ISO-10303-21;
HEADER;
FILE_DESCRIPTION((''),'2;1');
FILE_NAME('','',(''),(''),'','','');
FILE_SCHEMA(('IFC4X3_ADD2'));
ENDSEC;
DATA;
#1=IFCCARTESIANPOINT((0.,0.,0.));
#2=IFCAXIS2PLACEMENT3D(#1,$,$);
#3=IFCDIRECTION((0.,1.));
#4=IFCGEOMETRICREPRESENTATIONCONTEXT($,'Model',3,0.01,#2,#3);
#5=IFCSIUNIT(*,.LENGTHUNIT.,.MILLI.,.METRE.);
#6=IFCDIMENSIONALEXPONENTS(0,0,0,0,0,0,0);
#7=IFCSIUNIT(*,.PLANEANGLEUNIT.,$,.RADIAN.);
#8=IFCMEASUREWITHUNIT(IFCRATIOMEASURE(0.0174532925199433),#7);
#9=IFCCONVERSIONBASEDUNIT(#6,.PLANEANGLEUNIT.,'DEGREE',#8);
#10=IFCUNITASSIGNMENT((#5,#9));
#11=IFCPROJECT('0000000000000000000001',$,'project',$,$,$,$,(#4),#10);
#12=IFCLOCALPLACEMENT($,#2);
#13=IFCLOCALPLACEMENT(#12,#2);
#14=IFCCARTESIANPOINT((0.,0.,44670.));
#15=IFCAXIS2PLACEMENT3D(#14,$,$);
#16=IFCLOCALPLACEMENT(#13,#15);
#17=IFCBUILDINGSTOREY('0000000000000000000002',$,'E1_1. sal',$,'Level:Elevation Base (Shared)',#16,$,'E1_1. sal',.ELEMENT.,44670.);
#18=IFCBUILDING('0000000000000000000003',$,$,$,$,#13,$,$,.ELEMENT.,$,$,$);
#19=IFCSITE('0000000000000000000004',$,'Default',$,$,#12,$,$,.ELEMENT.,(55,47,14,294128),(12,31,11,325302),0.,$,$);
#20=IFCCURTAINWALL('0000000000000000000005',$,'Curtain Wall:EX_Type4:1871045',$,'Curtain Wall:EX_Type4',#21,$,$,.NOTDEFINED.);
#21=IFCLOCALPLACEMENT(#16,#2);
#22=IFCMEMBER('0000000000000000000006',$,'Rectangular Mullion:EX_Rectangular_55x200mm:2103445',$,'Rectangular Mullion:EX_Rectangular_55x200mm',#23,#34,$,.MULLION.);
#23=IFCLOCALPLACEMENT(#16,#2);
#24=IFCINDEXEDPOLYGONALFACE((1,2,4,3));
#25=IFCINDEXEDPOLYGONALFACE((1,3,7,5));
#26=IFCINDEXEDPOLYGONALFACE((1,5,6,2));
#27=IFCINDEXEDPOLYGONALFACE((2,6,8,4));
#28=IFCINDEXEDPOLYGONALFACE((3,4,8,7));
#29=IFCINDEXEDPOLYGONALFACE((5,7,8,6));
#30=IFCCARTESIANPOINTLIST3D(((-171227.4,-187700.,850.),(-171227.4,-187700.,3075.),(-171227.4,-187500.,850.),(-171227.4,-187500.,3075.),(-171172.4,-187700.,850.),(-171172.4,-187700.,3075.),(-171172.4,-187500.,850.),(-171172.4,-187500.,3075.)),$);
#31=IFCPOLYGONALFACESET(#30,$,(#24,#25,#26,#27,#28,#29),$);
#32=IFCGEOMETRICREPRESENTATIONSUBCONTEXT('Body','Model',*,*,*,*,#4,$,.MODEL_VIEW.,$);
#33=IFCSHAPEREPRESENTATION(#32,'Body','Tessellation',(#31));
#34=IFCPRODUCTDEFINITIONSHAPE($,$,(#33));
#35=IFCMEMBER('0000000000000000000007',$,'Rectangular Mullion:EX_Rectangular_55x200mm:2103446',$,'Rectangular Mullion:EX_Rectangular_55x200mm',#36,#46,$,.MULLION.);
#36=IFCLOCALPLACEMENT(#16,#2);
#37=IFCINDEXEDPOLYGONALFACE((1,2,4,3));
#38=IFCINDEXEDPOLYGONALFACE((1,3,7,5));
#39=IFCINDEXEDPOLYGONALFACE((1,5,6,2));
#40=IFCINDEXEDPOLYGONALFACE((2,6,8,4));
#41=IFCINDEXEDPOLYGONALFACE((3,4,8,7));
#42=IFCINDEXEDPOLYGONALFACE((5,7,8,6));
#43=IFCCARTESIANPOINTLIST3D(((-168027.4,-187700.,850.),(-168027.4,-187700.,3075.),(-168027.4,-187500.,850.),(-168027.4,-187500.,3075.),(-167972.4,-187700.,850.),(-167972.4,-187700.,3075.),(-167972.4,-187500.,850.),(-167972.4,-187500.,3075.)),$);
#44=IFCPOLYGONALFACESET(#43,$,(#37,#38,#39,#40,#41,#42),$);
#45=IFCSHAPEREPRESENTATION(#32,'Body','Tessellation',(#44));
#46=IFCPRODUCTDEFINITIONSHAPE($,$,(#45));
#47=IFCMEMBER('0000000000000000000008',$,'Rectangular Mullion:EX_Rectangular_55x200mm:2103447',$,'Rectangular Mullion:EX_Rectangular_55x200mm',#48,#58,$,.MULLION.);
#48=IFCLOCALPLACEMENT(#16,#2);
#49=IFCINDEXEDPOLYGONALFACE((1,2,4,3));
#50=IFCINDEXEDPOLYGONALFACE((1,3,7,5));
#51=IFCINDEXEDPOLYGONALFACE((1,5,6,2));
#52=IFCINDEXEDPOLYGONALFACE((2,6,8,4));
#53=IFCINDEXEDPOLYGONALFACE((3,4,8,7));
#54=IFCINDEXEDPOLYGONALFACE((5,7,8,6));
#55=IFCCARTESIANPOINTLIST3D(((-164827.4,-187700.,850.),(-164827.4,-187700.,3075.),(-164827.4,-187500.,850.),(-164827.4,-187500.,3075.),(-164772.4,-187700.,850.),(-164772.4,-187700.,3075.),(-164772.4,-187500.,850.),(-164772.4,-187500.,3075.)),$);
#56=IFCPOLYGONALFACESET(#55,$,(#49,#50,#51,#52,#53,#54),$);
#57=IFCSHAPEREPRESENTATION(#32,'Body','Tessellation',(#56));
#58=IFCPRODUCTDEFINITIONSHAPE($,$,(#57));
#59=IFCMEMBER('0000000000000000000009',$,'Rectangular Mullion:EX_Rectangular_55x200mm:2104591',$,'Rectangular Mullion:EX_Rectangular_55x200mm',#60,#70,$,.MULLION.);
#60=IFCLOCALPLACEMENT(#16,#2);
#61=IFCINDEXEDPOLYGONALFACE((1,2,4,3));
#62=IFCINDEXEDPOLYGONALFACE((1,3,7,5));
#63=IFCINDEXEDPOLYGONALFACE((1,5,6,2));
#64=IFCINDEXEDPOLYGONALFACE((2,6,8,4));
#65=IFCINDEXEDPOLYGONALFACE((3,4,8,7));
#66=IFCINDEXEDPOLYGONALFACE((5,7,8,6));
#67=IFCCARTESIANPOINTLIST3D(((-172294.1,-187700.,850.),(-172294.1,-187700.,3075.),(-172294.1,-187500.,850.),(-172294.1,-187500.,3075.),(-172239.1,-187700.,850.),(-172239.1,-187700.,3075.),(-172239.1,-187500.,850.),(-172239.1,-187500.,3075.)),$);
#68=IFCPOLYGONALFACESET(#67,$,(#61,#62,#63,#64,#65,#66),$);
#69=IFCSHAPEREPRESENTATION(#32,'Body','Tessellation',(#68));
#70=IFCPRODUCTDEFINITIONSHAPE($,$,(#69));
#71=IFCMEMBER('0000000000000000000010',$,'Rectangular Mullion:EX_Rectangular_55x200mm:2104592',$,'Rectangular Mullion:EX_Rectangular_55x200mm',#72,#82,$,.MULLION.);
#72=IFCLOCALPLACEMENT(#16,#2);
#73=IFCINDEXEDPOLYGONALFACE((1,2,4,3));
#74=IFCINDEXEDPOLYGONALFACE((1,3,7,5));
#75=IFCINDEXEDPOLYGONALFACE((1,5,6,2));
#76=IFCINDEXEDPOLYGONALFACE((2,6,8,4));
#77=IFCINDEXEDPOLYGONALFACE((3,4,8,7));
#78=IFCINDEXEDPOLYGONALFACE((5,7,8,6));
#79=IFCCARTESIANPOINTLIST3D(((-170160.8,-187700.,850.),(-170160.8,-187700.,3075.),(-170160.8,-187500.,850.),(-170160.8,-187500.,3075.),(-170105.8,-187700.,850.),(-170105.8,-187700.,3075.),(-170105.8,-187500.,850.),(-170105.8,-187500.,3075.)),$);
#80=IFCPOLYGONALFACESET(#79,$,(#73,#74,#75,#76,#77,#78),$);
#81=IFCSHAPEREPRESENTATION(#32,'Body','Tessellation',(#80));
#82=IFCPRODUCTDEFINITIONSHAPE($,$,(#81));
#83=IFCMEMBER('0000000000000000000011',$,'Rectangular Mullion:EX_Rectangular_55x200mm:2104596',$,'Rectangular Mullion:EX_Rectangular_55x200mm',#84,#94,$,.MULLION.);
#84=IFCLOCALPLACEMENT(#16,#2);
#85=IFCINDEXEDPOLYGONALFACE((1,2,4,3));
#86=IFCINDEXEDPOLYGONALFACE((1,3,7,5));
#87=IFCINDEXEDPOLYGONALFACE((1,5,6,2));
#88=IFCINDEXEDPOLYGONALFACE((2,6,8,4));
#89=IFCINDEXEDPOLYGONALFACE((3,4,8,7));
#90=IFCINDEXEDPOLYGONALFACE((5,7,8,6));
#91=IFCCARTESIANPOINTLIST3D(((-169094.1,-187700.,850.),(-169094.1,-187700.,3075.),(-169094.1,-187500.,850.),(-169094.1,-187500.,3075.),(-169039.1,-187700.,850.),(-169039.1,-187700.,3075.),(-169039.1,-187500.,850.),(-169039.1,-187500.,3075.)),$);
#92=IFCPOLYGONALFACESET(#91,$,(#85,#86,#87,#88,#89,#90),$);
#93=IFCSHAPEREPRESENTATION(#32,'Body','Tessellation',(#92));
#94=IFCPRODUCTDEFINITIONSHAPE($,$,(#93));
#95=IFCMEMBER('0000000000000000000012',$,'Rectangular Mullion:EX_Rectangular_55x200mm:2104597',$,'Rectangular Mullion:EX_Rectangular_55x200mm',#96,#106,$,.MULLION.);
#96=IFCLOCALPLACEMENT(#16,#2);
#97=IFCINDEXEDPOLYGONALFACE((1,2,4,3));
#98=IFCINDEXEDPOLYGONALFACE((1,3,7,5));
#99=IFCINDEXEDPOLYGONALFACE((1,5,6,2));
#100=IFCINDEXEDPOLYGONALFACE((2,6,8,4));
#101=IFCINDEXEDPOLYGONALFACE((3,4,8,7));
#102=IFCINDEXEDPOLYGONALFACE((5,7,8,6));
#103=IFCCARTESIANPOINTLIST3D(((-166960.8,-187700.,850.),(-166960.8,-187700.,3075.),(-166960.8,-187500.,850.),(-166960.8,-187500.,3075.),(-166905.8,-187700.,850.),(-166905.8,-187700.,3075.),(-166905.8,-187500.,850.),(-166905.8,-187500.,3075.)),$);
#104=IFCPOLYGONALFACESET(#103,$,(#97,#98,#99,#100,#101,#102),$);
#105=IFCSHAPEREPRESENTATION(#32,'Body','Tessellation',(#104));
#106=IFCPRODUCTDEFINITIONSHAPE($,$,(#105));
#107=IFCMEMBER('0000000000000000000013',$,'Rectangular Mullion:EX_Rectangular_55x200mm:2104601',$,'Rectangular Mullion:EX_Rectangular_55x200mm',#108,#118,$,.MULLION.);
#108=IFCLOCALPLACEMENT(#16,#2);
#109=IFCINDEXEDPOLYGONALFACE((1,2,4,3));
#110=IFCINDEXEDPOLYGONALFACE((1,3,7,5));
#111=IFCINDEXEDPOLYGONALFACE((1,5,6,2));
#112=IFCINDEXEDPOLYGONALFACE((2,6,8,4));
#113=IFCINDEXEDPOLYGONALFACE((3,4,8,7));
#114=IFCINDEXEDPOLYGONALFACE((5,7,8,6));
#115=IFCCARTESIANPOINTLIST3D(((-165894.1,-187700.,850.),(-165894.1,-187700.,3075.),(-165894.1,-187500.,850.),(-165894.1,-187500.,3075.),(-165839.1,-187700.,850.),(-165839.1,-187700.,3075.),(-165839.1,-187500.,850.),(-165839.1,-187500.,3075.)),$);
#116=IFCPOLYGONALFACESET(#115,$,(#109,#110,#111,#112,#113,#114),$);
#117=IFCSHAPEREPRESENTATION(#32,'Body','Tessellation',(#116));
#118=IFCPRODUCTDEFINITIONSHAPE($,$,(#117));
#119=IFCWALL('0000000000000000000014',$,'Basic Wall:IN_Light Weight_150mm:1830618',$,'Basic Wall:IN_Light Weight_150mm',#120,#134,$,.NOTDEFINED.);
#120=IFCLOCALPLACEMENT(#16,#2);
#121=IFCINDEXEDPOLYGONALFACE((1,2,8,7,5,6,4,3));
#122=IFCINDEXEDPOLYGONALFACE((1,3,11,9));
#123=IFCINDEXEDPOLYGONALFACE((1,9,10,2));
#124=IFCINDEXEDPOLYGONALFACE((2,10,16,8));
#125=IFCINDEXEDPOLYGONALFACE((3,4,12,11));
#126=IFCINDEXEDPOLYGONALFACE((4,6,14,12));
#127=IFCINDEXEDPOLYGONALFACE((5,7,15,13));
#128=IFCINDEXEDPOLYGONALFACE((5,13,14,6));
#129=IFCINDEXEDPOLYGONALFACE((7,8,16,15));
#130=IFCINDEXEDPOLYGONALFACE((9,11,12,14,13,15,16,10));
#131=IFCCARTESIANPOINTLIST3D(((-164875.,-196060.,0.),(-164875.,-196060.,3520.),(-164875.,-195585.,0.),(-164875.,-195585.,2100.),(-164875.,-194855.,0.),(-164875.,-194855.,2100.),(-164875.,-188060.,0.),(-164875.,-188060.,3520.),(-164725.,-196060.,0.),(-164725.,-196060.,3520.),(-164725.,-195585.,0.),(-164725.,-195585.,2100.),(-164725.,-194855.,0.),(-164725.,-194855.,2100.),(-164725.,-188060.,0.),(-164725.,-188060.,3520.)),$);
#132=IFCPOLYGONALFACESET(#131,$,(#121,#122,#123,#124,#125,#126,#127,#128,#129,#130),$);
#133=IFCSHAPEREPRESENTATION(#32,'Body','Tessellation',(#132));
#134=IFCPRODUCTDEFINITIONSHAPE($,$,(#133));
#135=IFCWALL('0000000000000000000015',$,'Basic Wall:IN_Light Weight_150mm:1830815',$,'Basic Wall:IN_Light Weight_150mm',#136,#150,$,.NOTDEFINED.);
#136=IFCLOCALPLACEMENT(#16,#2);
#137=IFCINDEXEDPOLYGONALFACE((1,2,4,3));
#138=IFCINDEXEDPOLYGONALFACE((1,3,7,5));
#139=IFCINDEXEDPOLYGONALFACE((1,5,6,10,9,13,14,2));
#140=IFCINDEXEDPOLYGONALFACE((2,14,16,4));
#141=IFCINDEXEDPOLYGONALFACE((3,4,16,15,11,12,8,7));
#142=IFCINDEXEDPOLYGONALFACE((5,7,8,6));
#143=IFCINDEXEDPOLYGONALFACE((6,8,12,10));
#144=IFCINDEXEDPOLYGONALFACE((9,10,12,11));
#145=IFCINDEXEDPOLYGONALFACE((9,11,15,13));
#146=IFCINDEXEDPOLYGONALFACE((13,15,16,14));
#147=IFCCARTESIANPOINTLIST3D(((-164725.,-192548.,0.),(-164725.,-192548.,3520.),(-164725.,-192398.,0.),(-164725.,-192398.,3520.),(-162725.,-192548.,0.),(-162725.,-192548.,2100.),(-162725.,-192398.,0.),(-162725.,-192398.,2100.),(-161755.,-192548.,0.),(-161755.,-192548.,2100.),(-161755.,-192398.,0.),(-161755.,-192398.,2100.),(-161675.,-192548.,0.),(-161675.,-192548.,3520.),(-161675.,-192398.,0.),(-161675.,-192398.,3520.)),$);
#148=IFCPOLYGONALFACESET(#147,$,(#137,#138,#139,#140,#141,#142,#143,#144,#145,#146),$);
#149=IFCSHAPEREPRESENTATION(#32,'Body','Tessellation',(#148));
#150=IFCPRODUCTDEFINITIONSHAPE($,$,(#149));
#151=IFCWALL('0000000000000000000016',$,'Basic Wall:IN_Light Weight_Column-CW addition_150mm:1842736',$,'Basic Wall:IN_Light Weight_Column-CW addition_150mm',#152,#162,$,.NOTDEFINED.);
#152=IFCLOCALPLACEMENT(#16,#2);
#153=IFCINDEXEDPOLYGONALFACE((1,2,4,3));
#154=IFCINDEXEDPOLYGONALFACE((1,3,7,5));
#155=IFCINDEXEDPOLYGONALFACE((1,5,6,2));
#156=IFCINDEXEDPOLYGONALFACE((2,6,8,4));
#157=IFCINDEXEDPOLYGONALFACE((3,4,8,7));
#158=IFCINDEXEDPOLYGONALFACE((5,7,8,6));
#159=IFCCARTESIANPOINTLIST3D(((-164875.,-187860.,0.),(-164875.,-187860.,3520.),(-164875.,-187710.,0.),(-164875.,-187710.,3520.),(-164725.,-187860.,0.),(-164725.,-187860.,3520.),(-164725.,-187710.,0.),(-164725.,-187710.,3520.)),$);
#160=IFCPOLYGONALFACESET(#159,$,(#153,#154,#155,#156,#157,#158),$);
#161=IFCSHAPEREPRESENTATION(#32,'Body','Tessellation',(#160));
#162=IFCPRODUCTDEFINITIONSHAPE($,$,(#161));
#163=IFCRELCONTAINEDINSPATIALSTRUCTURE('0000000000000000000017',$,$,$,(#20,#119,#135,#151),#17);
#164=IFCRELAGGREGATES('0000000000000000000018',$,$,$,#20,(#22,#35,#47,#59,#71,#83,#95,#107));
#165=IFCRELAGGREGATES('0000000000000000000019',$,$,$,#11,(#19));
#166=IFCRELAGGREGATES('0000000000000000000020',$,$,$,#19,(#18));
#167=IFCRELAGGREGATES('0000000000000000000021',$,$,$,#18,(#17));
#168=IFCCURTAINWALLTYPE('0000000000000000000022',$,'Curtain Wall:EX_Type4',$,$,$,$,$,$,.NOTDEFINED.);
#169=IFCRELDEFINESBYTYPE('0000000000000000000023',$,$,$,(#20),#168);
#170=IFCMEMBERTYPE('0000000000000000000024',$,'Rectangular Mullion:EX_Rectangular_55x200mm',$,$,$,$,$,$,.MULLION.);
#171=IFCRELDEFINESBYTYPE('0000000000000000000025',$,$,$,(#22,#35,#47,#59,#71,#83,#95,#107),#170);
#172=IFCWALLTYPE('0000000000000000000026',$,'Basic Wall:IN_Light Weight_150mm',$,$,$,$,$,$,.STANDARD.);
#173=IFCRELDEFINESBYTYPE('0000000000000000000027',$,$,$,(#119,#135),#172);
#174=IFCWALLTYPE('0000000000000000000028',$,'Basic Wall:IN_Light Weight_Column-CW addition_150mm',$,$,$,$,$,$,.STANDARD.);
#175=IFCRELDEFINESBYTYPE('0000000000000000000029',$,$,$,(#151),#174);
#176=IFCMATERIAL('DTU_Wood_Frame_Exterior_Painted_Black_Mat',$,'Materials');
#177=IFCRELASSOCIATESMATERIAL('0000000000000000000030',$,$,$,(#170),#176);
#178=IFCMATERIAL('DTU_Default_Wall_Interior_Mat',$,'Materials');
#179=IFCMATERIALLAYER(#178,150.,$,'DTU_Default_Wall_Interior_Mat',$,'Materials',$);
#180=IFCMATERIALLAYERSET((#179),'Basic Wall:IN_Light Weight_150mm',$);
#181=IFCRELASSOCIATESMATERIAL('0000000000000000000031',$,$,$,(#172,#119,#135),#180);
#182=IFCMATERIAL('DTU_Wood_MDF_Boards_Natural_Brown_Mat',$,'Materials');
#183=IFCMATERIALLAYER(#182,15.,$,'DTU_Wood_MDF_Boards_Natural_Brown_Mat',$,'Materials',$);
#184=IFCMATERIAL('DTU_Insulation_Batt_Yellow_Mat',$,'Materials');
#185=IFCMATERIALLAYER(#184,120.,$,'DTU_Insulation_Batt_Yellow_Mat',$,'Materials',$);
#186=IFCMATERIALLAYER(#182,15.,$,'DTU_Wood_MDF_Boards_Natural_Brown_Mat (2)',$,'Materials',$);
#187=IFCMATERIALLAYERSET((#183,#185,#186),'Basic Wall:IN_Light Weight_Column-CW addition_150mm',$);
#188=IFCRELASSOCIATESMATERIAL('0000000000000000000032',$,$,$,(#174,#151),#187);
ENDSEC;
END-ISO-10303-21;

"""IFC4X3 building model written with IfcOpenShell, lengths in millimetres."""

from ifc_helpers import new_model, entity, si_unit, converted_unit, direction, frame, frame_2d, origin, origin_2d_with_axis, place, context, subcontext, project, spatial, rectangle, extrude, source, transform, mapped, material, layer, layer_set, material_profile, profile_set, type_object, type_shapes, element, aggregate, save


model = new_model("IFC4X3")

# Units and contexts
model_context = context("Model", 3, precision=0.01, world=origin(), true_north=direction((0.0, 1.0)))
body_context = subcontext(model_context, "Body", "Model", "MODEL_VIEW")
ifc_project = project(units=[si_unit("LENGTHUNIT", "METRE", prefix="MILLI"), converted_unit("PLANEANGLEUNIT", "DEGREE", entity("IfcRatioMeasure", 0.0174532925199433), si_unit("PLANEANGLEUNIT", "RADIAN"), dimensions=[0, 0, 0, 0, 0, 0, 0])], contexts=[model_context])

# Site, building, storey
site_placement = place(None, origin())
site = spatial("IfcSite", under=ifc_project, at=site_placement, Name="Default", CompositionType="ELEMENT", RefLatitude=(55, 47, 14, 294128), RefLongitude=(12, 31, 11, 325302), RefElevation=0.0)
building_placement = place(site_placement, origin())
building = spatial("IfcBuilding", under=site, at=building_placement, CompositionType="ELEMENT")
storey_placement = place(building_placement, frame((0.0, 0.0, 44670.0)))
storey = spatial("IfcBuildingStorey", under=building, at=storey_placement, Name="E1_1. sal", ObjectType="Level:Elevation Base (Shared)", LongName="E1_1. sal", CompositionType="ELEMENT", Elevation=44670.0)

# Curtain wall, members
curtain_wall_type = type_object("IfcCurtainWallType", Name="Curtain Wall:EX_Type4", PredefinedType="NOTDEFINED")
curtain_wall_placement = place(storey_placement, frame((0.0, 0.0, -44670.0)))
curtain_wall = element("IfcCurtainWall", 1, at=curtain_wall_placement, inside=storey, type_object=curtain_wall_type, Name="Curtain Wall:EX_Type4:1871045", ObjectType="Curtain Wall:EX_Type4", PredefinedType="NOTDEFINED")
ifc_material_1 = material(Name="DTU_Wood_Frame_Exterior_Painted_Black_Mat", Category="Materials")
ifc_material_profile = material_profile(ifc_material_1, rectangle(XDim=200.0, YDim=55.0, at=origin_2d_with_axis()), Name="EX_Rectangular_55x200mm")
ifc_profile_set = profile_set([ifc_material_profile], Name="EX_Rectangular_55x200mm")
member_type = type_object("IfcMemberType", Name="Rectangular Mullion:EX_Rectangular_55x200mm", PredefinedType="MULLION", material=ifc_profile_set)
shared_shape_1 = source(origin(), body_context, "Body", "SweptSolid", [
    extrude(rectangle(XDim=200.0, YDim=55.0, at=origin_2d_with_axis()), frame((0.0, -100.0, -2225.0), z_axis=(0.0, 0.0, 1.0), x_axis=(0.0, -1.0, 0.0)), (0.0, 0.0, 1.0), 2225.0),
])
type_shapes(member_type, [shared_shape_1])
member_1_placement = place(curtain_wall_placement, frame((-171199.9, -187500.0, 45520.0), z_axis=(0.0, 0.0, -1.0), x_axis=(-1.0, 0.0, 0.0)))
member_1 = element("IfcMember", 2, at=member_1_placement, type_object=member_type, Name="Rectangular Mullion:EX_Rectangular_55x200mm:2103445", ObjectType="Rectangular Mullion:EX_Rectangular_55x200mm", PredefinedType="MULLION", context=body_context, shape_type="MappedRepresentation", body=[
    mapped(shared_shape_1, transform((0.0, 0.0, 0.0), scale=1.0)),
])
member_2_placement = place(curtain_wall_placement, frame((-167999.9, -187500.0, 45520.0), z_axis=(0.0, 0.0, -1.0), x_axis=(-1.0, 0.0, 0.0)))
member_2 = element("IfcMember", 3, at=member_2_placement, type_object=member_type, Name="Rectangular Mullion:EX_Rectangular_55x200mm:2103446", ObjectType="Rectangular Mullion:EX_Rectangular_55x200mm", PredefinedType="MULLION", context=body_context, shape_type="MappedRepresentation", body=[
    mapped(shared_shape_1, transform((0.0, 0.0, 0.0), scale=1.0)),
])
member_3_placement = place(curtain_wall_placement, frame((-164799.9, -187500.0, 45520.0), z_axis=(0.0, 0.0, -1.0), x_axis=(-1.0, 0.0, 0.0)))
member_3 = element("IfcMember", 4, at=member_3_placement, type_object=member_type, Name="Rectangular Mullion:EX_Rectangular_55x200mm:2103447", ObjectType="Rectangular Mullion:EX_Rectangular_55x200mm", PredefinedType="MULLION", context=body_context, shape_type="MappedRepresentation", body=[
    mapped(shared_shape_1, transform((0.0, 0.0, 0.0), scale=1.0)),
])
member_4_placement = place(curtain_wall_placement, frame((-172266.6, -187500.0, 45520.0), z_axis=(0.0, 0.0, -1.0), x_axis=(-1.0, 0.0, 0.0)))
member_4 = element("IfcMember", 5, at=member_4_placement, type_object=member_type, Name="Rectangular Mullion:EX_Rectangular_55x200mm:2104591", ObjectType="Rectangular Mullion:EX_Rectangular_55x200mm", PredefinedType="MULLION", context=body_context, shape_type="MappedRepresentation", body=[
    mapped(shared_shape_1, transform((0.0, 0.0, 0.0), scale=1.0)),
])
member_5_placement = place(curtain_wall_placement, frame((-170133.3, -187500.0, 45520.0), z_axis=(0.0, 0.0, -1.0), x_axis=(-1.0, 0.0, 0.0)))
member_5 = element("IfcMember", 6, at=member_5_placement, type_object=member_type, Name="Rectangular Mullion:EX_Rectangular_55x200mm:2104592", ObjectType="Rectangular Mullion:EX_Rectangular_55x200mm", PredefinedType="MULLION", context=body_context, shape_type="MappedRepresentation", body=[
    mapped(shared_shape_1, transform((0.0, 0.0, 0.0), scale=1.0)),
])
member_6_placement = place(curtain_wall_placement, frame((-169066.6, -187500.0, 45520.0), z_axis=(0.0, 0.0, -1.0), x_axis=(-1.0, 0.0, 0.0)))
member_6 = element("IfcMember", 7, at=member_6_placement, type_object=member_type, Name="Rectangular Mullion:EX_Rectangular_55x200mm:2104596", ObjectType="Rectangular Mullion:EX_Rectangular_55x200mm", PredefinedType="MULLION", context=body_context, shape_type="MappedRepresentation", body=[
    mapped(shared_shape_1, transform((0.0, 0.0, 0.0), scale=1.0)),
])
member_7_placement = place(curtain_wall_placement, frame((-166933.3, -187500.0, 45520.0), z_axis=(0.0, 0.0, -1.0), x_axis=(-1.0, 0.0, 0.0)))
member_7 = element("IfcMember", 8, at=member_7_placement, type_object=member_type, Name="Rectangular Mullion:EX_Rectangular_55x200mm:2104597", ObjectType="Rectangular Mullion:EX_Rectangular_55x200mm", PredefinedType="MULLION", context=body_context, shape_type="MappedRepresentation", body=[
    mapped(shared_shape_1, transform((0.0, 0.0, 0.0), scale=1.0)),
])
member_8_placement = place(curtain_wall_placement, frame((-165866.6, -187500.0, 45520.0), z_axis=(0.0, 0.0, -1.0), x_axis=(-1.0, 0.0, 0.0)))
member_8 = element("IfcMember", 9, at=member_8_placement, type_object=member_type, Name="Rectangular Mullion:EX_Rectangular_55x200mm:2104601", ObjectType="Rectangular Mullion:EX_Rectangular_55x200mm", PredefinedType="MULLION", context=body_context, shape_type="MappedRepresentation", body=[
    mapped(shared_shape_1, transform((0.0, 0.0, 0.0), scale=1.0)),
])

# Walls, openings
ifc_material_2 = material(Name="DTU_Default_Wall_Interior_Mat", Category="Materials")
ifc_layer_1 = layer(ifc_material_2, 150.0, Name="DTU_Default_Wall_Interior_Mat", Category="Materials")
ifc_layer_set_1 = layer_set([ifc_layer_1], Name="Basic Wall:IN_Light Weight_150mm")
wall_type_1 = type_object("IfcWallType", Name="Basic Wall:IN_Light Weight_150mm", PredefinedType="STANDARD", material=ifc_layer_set_1)
wall_1_placement = place(storey_placement, frame((-164800.0, -188060.0, 0.0), z_axis=(0.0, 0.0, 1.0), x_axis=(0.0, -1.0, 0.0)))
wall_1 = element("IfcWall", 10, at=wall_1_placement, inside=storey, type_object=wall_type_1, material=ifc_layer_set_1, Name="Basic Wall:IN_Light Weight_150mm:1830618", ObjectType="Basic Wall:IN_Light Weight_150mm", PredefinedType="NOTDEFINED", context=body_context, shape_type="SweptSolid", body=[
    extrude(rectangle(XDim=8000.0, YDim=150.0, at=frame_2d((4000.0, 0.0), x_axis=(1.0, 0.0))), origin(), (0.0, 0.0, 1.0), 3520.0),
])
opening_1_placement = place(wall_1_placement, frame((6795.0, -75.0, 0.0)))
element("IfcOpeningElement", 11, at=opening_1_placement, cuts=wall_1, PredefinedType="OPENING", context=body_context, shape_type="SweptSolid", body=[
    extrude(rectangle(XDim=2100.0, YDim=730.0, at=frame_2d((1050.0, 365.0), x_axis=(1.0, 0.0))), frame((0.0, 0.0, 0.0), z_axis=(0.0, 1.0, 0.0), x_axis=(0.0, 0.0, 1.0)), (0.0, 0.0, 1.0), 150.0),
])
wall_2_placement = place(storey_placement, frame((-164725.0, -192473.0, 0.0)))
wall_2 = element("IfcWall", 12, at=wall_2_placement, inside=storey, type_object=wall_type_1, material=ifc_layer_set_1, Name="Basic Wall:IN_Light Weight_150mm:1830815", ObjectType="Basic Wall:IN_Light Weight_150mm", PredefinedType="NOTDEFINED", context=body_context, shape_type="SweptSolid", body=[
    extrude(rectangle(XDim=3050.0, YDim=150.0, at=frame_2d((1525.0, 0.0), x_axis=(1.0, 0.0))), origin(), (0.0, 0.0, 1.0), 3520.0),
])
opening_2_placement = place(wall_2_placement, frame((2970.0, 75.0, 0.0)))
element("IfcOpeningElement", 13, at=opening_2_placement, cuts=wall_2, PredefinedType="OPENING", context=body_context, shape_type="SweptSolid", body=[
    extrude(rectangle(XDim=2100.0, YDim=970.0, at=frame_2d((1050.0, 485.0), x_axis=(1.0, 0.0))), frame((0.0, 0.0, 0.0), z_axis=(0.0, -1.0, 0.0), x_axis=(0.0, 0.0, 1.0)), (0.0, 0.0, 1.0), 150.0),
])

# Wall
ifc_material_3 = material(Name="DTU_Wood_MDF_Boards_Natural_Brown_Mat", Category="Materials")
ifc_layer_2 = layer(ifc_material_3, 15.0, Name="DTU_Wood_MDF_Boards_Natural_Brown_Mat", Category="Materials")
ifc_material_4 = material(Name="DTU_Insulation_Batt_Yellow_Mat", Category="Materials")
ifc_layer_3 = layer(ifc_material_4, 120.0, Name="DTU_Insulation_Batt_Yellow_Mat", Category="Materials")
ifc_layer_4 = layer(ifc_material_3, 15.0, Name="DTU_Wood_MDF_Boards_Natural_Brown_Mat (2)", Category="Materials")
ifc_layer_set_2 = layer_set([ifc_layer_2, ifc_layer_3, ifc_layer_4], Name="Basic Wall:IN_Light Weight_Column-CW addition_150mm")
wall_type_2 = type_object("IfcWallType", Name="Basic Wall:IN_Light Weight_Column-CW addition_150mm", PredefinedType="STANDARD", material=ifc_layer_set_2)
wall_3_placement = place(storey_placement, frame((-164800.0, -187710.0, 0.0), z_axis=(0.0, 0.0, 1.0), x_axis=(0.0, -1.0, 0.0)))
element("IfcWall", 14, at=wall_3_placement, inside=storey, type_object=wall_type_2, material=ifc_layer_set_2, Name="Basic Wall:IN_Light Weight_Column-CW addition_150mm:1842736", ObjectType="Basic Wall:IN_Light Weight_Column-CW addition_150mm", PredefinedType="NOTDEFINED", context=body_context, shape_type="SweptSolid", body=[
    extrude(rectangle(XDim=150.0, YDim=150.0, at=frame_2d((75.0, 0.0), x_axis=(-1.0, 0.0))), origin(), (0.0, 0.0, 1.0), 3520.0),
])

aggregate(curtain_wall, [member_1, member_2, member_3, member_4, member_5, member_6, member_7, member_8])

save(model, "model.ifc")
